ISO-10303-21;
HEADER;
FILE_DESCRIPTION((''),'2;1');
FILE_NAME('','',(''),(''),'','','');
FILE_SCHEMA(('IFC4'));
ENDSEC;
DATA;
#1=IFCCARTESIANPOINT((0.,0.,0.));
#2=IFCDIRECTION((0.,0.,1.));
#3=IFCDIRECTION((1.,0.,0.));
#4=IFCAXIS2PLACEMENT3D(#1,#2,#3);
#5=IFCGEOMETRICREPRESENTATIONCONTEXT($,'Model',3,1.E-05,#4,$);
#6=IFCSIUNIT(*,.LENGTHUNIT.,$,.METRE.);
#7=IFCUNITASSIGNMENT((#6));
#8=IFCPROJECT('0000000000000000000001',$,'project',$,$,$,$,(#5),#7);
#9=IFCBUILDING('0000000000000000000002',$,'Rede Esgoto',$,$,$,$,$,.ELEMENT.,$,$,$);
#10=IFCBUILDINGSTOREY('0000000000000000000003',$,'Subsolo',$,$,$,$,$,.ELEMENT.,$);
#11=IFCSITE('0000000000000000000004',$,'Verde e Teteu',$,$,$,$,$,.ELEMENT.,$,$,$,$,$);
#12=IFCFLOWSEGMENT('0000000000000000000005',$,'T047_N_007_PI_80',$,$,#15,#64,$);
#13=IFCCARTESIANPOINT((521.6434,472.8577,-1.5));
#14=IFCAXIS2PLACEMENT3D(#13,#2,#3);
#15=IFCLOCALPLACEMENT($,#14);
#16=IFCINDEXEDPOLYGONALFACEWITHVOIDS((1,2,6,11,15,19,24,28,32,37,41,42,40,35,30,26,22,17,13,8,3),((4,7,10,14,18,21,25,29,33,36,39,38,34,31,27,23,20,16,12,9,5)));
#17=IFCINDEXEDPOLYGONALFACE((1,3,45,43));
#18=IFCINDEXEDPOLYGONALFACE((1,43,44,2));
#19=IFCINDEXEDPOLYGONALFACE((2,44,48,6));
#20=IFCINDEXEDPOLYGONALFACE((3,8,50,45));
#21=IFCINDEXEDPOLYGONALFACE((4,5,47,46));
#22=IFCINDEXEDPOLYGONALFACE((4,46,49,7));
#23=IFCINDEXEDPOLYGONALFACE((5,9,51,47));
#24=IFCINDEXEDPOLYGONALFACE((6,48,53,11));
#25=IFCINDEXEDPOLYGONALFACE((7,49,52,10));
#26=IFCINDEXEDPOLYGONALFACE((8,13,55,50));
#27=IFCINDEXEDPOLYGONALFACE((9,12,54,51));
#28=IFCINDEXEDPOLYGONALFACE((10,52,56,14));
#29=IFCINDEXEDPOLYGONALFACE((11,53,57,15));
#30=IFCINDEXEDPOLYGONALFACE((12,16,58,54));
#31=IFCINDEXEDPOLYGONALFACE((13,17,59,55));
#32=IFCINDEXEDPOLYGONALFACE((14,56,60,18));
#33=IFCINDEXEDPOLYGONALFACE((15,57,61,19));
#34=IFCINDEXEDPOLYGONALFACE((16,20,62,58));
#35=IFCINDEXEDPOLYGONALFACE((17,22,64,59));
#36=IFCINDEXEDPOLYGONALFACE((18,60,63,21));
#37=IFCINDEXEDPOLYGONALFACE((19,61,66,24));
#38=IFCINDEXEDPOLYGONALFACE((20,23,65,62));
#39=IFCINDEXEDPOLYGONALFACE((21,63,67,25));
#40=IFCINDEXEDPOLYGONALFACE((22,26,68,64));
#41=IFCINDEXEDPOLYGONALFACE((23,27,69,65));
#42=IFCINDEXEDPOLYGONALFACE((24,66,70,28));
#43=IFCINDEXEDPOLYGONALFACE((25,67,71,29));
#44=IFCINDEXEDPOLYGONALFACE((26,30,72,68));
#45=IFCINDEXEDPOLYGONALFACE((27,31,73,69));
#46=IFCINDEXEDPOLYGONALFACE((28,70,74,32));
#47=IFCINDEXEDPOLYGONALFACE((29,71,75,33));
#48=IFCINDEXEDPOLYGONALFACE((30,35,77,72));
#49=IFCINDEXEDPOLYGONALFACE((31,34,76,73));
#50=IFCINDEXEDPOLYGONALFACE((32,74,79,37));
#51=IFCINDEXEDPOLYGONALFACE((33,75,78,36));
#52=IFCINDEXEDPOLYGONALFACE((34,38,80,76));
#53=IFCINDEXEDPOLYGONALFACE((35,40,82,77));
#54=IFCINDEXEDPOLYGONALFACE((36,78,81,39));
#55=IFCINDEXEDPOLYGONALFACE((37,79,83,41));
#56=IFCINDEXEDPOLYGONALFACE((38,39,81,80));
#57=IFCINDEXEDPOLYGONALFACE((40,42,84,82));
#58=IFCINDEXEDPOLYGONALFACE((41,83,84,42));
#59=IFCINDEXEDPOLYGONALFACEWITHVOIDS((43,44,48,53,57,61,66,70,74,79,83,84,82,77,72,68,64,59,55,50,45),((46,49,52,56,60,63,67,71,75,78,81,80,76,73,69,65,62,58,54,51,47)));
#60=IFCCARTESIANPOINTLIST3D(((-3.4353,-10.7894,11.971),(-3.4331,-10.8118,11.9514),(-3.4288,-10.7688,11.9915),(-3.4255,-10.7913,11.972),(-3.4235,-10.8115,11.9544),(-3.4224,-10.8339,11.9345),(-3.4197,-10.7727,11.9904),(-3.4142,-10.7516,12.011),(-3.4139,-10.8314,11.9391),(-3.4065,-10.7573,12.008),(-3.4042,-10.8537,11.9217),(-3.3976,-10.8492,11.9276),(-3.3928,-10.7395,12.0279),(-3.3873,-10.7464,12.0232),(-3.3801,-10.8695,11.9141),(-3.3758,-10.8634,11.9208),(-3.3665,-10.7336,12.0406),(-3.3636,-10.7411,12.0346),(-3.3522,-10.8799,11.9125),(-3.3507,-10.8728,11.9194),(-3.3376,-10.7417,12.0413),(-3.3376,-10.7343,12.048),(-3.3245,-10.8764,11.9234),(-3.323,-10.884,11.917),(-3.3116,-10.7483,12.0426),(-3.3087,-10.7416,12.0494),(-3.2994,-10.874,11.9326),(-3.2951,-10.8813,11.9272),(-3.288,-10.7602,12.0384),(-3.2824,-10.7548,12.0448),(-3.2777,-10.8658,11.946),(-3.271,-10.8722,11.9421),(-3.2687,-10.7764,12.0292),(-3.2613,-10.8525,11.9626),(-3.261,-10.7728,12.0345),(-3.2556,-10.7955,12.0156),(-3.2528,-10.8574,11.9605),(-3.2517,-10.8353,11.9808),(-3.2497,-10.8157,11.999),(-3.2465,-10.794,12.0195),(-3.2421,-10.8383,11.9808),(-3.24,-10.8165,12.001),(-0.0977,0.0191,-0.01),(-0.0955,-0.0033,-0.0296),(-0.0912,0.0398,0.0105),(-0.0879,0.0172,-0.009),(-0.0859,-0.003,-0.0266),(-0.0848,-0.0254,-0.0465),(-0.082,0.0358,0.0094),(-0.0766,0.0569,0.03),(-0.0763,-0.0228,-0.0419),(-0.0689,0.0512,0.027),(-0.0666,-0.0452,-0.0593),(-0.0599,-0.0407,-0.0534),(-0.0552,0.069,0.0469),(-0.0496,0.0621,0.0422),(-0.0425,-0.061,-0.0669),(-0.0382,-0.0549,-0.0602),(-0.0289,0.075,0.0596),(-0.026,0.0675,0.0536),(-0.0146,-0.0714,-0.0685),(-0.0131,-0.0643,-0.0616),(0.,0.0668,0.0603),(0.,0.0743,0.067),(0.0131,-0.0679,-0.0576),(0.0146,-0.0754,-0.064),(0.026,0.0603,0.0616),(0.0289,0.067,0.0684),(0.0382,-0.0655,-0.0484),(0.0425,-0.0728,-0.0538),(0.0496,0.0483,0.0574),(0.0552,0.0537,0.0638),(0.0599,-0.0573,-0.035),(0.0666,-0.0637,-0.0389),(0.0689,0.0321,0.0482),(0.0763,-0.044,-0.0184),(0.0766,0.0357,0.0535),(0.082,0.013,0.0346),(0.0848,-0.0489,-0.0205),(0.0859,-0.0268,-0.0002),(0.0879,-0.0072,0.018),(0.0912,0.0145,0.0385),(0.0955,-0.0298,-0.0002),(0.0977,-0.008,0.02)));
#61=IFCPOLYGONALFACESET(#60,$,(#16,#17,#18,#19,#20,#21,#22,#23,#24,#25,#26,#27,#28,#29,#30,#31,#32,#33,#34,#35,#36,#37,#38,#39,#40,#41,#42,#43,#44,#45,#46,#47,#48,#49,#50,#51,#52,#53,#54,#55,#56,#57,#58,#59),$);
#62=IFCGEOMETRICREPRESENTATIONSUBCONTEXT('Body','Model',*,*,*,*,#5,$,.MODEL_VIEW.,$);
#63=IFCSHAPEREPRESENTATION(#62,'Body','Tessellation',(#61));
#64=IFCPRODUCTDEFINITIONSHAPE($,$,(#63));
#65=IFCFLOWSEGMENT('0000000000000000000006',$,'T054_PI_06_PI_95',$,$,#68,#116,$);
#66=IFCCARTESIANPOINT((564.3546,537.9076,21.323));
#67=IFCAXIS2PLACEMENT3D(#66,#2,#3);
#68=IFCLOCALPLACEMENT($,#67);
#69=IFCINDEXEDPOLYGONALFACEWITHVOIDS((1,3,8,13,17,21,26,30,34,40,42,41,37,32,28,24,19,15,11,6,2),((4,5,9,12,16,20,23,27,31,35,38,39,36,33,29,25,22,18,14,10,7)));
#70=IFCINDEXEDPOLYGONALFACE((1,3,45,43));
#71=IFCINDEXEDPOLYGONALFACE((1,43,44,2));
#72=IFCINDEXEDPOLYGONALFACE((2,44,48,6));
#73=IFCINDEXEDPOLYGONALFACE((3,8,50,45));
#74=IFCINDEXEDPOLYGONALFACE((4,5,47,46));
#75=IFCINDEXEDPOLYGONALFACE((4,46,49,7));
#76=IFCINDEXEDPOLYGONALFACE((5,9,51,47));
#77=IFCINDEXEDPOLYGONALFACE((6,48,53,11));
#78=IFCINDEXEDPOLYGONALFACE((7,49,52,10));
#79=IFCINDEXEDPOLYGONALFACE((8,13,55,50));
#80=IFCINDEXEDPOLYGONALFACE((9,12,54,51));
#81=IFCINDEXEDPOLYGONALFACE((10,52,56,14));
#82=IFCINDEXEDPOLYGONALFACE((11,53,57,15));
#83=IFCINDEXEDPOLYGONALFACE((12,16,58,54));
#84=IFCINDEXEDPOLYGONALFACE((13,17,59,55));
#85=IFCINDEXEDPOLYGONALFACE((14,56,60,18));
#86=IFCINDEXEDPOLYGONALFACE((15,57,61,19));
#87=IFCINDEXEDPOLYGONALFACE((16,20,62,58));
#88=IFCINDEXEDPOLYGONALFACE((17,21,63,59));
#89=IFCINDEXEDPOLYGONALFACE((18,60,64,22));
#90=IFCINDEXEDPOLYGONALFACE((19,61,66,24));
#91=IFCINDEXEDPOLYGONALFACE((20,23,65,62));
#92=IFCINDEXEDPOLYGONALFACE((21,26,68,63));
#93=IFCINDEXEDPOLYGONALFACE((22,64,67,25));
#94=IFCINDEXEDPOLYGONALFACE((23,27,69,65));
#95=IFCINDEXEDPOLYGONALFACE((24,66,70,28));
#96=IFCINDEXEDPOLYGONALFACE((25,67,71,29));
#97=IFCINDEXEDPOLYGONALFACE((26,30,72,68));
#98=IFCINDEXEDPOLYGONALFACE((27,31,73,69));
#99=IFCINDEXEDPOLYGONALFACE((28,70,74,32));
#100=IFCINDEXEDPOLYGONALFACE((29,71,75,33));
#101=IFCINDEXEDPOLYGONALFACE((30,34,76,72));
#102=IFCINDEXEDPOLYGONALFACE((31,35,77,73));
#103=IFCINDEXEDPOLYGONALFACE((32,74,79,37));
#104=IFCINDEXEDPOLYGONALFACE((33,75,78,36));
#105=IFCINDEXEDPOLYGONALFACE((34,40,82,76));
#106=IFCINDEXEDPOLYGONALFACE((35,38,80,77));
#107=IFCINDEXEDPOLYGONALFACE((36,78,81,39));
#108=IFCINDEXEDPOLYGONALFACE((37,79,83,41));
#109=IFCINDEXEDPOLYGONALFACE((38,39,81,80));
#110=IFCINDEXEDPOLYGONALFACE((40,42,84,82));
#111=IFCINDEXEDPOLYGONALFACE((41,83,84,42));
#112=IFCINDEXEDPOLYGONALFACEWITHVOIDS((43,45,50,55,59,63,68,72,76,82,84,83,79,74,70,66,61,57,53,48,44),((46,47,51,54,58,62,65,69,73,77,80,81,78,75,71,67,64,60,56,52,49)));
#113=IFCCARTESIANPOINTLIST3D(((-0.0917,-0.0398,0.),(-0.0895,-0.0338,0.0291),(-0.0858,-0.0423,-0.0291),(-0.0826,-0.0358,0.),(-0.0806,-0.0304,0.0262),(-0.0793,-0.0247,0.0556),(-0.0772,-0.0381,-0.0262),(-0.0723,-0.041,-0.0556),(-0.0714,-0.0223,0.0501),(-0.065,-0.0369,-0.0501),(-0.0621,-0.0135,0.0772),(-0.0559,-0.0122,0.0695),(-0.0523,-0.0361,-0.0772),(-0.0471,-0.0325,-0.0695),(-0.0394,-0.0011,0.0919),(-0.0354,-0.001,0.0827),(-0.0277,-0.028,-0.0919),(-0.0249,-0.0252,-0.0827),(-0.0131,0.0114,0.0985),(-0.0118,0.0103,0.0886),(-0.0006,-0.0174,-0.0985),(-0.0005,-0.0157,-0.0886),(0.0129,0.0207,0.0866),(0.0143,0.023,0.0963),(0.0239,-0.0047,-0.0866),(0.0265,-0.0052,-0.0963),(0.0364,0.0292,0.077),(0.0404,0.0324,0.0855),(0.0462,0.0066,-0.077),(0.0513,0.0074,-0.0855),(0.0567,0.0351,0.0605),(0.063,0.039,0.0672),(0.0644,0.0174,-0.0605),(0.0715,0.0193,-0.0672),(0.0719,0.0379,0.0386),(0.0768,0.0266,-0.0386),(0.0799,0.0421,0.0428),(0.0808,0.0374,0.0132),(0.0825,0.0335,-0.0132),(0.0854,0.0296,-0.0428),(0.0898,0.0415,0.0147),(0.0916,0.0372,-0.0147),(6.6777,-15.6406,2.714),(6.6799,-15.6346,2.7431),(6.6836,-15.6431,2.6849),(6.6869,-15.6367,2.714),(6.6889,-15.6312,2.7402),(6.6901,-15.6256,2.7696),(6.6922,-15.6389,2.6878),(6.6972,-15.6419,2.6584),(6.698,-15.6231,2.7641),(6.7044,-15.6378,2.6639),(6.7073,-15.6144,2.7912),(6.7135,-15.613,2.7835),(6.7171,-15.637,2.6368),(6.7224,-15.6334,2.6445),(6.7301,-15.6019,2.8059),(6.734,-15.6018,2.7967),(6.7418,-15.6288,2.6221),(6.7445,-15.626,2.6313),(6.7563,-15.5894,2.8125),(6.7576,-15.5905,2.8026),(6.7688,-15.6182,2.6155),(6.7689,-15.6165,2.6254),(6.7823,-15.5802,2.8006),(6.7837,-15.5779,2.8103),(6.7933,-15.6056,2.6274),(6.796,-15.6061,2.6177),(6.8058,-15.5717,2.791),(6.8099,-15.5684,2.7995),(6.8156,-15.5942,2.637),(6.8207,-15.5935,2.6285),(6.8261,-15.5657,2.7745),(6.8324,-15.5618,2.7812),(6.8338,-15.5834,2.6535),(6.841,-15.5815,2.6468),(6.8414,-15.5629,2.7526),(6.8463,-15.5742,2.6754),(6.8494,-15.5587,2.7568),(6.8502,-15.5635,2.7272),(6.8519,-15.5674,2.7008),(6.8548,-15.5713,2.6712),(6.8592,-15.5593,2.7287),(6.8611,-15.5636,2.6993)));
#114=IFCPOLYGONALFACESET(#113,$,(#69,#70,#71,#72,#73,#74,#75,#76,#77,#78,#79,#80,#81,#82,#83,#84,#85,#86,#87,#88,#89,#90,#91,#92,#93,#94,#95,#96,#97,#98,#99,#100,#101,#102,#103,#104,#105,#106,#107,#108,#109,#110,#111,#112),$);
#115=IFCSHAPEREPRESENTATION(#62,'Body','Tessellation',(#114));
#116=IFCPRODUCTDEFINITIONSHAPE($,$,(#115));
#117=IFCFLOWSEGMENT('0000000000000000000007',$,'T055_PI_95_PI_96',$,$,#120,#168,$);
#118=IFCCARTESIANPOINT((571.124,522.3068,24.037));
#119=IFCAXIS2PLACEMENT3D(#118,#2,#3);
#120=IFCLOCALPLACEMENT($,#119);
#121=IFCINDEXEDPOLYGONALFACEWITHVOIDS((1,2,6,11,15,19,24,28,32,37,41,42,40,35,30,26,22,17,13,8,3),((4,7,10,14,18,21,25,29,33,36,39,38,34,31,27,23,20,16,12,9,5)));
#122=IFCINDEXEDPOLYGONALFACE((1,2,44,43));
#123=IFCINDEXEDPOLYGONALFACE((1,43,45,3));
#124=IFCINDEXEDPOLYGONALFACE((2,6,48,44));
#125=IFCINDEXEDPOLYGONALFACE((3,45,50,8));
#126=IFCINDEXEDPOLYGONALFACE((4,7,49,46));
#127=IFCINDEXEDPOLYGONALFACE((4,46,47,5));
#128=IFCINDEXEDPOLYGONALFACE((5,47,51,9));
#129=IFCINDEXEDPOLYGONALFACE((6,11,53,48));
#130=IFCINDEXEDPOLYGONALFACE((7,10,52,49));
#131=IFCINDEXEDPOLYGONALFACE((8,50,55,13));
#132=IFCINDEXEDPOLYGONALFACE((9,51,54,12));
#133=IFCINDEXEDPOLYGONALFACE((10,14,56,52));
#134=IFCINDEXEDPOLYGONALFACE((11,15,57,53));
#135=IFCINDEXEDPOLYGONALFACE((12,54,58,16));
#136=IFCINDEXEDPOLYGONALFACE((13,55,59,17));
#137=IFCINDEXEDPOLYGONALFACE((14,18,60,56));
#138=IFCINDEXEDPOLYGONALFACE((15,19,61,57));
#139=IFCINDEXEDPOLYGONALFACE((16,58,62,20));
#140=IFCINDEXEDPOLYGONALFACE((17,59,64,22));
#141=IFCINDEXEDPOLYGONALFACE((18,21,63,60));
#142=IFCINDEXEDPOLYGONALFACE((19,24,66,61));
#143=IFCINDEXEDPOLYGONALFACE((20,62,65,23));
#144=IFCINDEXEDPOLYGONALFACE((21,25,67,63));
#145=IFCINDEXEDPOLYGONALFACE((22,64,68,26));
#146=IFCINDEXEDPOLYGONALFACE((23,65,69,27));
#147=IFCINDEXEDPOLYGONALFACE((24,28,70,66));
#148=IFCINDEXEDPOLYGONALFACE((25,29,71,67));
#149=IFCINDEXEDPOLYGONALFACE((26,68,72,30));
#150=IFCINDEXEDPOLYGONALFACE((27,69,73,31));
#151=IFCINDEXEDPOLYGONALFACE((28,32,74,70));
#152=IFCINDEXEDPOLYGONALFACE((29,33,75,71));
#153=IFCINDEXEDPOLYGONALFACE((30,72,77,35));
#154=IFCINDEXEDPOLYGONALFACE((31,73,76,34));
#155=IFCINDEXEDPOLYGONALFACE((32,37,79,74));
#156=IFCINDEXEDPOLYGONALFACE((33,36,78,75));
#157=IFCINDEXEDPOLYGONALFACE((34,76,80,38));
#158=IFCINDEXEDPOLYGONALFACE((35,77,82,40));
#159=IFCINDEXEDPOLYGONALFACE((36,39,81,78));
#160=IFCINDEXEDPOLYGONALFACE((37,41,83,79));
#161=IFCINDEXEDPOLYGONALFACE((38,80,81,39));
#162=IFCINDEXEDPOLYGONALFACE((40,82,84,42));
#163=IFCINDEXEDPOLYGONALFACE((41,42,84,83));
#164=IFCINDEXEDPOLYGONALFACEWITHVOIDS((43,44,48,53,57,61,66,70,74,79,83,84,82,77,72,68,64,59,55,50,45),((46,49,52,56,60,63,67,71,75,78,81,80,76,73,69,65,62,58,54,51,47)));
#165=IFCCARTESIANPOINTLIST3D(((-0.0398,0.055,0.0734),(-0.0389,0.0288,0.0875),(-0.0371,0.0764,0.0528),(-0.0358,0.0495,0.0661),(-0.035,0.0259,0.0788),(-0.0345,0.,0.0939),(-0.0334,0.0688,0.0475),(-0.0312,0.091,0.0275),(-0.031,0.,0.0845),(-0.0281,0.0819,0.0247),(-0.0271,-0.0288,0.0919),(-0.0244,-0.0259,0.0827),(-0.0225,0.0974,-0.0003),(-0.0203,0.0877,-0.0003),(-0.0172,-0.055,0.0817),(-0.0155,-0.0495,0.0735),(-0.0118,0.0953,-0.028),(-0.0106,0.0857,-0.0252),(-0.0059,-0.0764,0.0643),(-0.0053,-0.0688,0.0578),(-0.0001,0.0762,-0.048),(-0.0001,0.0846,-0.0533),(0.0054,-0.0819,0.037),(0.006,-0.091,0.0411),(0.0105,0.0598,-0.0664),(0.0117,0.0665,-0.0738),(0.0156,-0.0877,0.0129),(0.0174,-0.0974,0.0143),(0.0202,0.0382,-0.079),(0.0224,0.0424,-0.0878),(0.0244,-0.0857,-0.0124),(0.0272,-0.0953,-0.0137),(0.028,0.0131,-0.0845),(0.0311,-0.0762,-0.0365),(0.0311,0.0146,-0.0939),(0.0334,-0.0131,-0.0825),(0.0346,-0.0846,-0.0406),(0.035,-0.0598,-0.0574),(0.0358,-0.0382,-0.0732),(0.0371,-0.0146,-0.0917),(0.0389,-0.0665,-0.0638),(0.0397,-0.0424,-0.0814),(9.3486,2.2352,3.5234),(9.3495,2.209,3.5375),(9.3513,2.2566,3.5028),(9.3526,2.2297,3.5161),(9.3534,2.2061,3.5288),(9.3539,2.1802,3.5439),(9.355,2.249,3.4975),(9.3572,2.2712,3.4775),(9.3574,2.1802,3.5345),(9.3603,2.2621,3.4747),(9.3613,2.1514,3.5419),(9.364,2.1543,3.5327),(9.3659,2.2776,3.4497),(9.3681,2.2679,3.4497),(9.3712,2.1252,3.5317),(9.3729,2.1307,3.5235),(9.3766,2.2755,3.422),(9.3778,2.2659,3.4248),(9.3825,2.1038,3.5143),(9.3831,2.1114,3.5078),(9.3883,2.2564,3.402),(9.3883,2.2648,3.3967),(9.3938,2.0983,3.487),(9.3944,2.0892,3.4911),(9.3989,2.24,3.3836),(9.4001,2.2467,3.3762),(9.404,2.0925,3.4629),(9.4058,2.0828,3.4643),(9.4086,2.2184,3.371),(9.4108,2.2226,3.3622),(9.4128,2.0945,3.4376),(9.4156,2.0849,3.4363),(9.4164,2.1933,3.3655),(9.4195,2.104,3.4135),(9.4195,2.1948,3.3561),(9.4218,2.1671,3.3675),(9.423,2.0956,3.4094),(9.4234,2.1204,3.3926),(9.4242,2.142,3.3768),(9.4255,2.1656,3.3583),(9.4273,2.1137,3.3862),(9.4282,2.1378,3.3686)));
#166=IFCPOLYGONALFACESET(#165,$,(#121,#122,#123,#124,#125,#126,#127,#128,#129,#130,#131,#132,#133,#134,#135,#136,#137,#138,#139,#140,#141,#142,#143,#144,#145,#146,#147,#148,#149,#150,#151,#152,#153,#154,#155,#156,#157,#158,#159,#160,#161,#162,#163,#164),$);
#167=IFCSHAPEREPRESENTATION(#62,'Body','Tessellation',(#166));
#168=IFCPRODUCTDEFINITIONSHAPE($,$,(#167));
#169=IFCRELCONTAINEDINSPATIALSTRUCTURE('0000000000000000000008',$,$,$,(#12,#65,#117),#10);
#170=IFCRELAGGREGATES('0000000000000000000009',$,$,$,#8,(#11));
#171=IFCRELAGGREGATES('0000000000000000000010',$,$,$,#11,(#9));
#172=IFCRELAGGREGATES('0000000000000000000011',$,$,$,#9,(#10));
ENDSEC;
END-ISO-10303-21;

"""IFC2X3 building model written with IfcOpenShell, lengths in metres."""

from ifc_helpers import new_model, entity, si_unit, frame, origin_with_axes, place, context, subcontext, project, spatial, element, save


model = new_model("IFC2X3")

# Units and contexts
model_context = context("Model", 3, precision=1e-05, world=origin_with_axes())
body_context = subcontext(model_context, "Body", "Model", "MODEL_VIEW")
ifc_project = project(units=[si_unit("LENGTHUNIT", "METRE")], contexts=[model_context])

# Site, building, storey
site = spatial("IfcSite", under=ifc_project, Name="Verde e Teteu", CompositionType="ELEMENT")
building = spatial("IfcBuilding", under=site, Name="Rede Esgoto", CompositionType="ELEMENT")
storey = spatial("IfcBuildingStorey", under=building, Name="Subsolo", CompositionType="ELEMENT")

# Flow segments
flow_segment_1_placement = place(None, frame((521.6434, 472.8577, -1.5), z_axis=(0.0, 0.0, 1.0), x_axis=(1.0, 0.0, 0.0)))
element("IfcFlowSegment", 1, at=flow_segment_1_placement, inside=storey, Name="T047_N_007_PI_80", context=body_context, shape_type="SweptSolid", body=[
    entity("IfcSweptDiskSolid", entity("IfcPolyline", [entity("IfcCartesianPoint", [0.0, 0.0, 0.0]), entity("IfcCartesianPoint", [-3.3376, -10.8085, 11.981])]), 0.1, 0.09),
])
flow_segment_2_placement = place(None, frame((564.3546, 537.9076, 21.323), z_axis=(0.0, 0.0, 1.0), x_axis=(1.0, 0.0, 0.0)))
element("IfcFlowSegment", 2, at=flow_segment_2_placement, inside=storey, Name="T054_PI_06_PI_95", context=body_context, shape_type="SweptSolid", body=[
    entity("IfcSweptDiskSolid", entity("IfcPolyline", [entity("IfcCartesianPoint", [0.0, 0.0, 0.0]), entity("IfcCartesianPoint", [6.7694, -15.6008, 2.714])]), 0.1, 0.09),
])
flow_segment_3_placement = place(None, frame((571.124, 522.3068, 24.037), z_axis=(0.0, 0.0, 1.0), x_axis=(1.0, 0.0, 0.0)))
element("IfcFlowSegment", 3, at=flow_segment_3_placement, inside=storey, Name="T055_PI_95_PI_96", context=body_context, shape_type="SweptSolid", body=[
    entity("IfcSweptDiskSolid", entity("IfcPolyline", [entity("IfcCartesianPoint", [0.0, 0.0, 0.0]), entity("IfcCartesianPoint", [9.3884, 2.1802, 3.45])]), 0.1, 0.09),
])

save(model, "model.ifc")
